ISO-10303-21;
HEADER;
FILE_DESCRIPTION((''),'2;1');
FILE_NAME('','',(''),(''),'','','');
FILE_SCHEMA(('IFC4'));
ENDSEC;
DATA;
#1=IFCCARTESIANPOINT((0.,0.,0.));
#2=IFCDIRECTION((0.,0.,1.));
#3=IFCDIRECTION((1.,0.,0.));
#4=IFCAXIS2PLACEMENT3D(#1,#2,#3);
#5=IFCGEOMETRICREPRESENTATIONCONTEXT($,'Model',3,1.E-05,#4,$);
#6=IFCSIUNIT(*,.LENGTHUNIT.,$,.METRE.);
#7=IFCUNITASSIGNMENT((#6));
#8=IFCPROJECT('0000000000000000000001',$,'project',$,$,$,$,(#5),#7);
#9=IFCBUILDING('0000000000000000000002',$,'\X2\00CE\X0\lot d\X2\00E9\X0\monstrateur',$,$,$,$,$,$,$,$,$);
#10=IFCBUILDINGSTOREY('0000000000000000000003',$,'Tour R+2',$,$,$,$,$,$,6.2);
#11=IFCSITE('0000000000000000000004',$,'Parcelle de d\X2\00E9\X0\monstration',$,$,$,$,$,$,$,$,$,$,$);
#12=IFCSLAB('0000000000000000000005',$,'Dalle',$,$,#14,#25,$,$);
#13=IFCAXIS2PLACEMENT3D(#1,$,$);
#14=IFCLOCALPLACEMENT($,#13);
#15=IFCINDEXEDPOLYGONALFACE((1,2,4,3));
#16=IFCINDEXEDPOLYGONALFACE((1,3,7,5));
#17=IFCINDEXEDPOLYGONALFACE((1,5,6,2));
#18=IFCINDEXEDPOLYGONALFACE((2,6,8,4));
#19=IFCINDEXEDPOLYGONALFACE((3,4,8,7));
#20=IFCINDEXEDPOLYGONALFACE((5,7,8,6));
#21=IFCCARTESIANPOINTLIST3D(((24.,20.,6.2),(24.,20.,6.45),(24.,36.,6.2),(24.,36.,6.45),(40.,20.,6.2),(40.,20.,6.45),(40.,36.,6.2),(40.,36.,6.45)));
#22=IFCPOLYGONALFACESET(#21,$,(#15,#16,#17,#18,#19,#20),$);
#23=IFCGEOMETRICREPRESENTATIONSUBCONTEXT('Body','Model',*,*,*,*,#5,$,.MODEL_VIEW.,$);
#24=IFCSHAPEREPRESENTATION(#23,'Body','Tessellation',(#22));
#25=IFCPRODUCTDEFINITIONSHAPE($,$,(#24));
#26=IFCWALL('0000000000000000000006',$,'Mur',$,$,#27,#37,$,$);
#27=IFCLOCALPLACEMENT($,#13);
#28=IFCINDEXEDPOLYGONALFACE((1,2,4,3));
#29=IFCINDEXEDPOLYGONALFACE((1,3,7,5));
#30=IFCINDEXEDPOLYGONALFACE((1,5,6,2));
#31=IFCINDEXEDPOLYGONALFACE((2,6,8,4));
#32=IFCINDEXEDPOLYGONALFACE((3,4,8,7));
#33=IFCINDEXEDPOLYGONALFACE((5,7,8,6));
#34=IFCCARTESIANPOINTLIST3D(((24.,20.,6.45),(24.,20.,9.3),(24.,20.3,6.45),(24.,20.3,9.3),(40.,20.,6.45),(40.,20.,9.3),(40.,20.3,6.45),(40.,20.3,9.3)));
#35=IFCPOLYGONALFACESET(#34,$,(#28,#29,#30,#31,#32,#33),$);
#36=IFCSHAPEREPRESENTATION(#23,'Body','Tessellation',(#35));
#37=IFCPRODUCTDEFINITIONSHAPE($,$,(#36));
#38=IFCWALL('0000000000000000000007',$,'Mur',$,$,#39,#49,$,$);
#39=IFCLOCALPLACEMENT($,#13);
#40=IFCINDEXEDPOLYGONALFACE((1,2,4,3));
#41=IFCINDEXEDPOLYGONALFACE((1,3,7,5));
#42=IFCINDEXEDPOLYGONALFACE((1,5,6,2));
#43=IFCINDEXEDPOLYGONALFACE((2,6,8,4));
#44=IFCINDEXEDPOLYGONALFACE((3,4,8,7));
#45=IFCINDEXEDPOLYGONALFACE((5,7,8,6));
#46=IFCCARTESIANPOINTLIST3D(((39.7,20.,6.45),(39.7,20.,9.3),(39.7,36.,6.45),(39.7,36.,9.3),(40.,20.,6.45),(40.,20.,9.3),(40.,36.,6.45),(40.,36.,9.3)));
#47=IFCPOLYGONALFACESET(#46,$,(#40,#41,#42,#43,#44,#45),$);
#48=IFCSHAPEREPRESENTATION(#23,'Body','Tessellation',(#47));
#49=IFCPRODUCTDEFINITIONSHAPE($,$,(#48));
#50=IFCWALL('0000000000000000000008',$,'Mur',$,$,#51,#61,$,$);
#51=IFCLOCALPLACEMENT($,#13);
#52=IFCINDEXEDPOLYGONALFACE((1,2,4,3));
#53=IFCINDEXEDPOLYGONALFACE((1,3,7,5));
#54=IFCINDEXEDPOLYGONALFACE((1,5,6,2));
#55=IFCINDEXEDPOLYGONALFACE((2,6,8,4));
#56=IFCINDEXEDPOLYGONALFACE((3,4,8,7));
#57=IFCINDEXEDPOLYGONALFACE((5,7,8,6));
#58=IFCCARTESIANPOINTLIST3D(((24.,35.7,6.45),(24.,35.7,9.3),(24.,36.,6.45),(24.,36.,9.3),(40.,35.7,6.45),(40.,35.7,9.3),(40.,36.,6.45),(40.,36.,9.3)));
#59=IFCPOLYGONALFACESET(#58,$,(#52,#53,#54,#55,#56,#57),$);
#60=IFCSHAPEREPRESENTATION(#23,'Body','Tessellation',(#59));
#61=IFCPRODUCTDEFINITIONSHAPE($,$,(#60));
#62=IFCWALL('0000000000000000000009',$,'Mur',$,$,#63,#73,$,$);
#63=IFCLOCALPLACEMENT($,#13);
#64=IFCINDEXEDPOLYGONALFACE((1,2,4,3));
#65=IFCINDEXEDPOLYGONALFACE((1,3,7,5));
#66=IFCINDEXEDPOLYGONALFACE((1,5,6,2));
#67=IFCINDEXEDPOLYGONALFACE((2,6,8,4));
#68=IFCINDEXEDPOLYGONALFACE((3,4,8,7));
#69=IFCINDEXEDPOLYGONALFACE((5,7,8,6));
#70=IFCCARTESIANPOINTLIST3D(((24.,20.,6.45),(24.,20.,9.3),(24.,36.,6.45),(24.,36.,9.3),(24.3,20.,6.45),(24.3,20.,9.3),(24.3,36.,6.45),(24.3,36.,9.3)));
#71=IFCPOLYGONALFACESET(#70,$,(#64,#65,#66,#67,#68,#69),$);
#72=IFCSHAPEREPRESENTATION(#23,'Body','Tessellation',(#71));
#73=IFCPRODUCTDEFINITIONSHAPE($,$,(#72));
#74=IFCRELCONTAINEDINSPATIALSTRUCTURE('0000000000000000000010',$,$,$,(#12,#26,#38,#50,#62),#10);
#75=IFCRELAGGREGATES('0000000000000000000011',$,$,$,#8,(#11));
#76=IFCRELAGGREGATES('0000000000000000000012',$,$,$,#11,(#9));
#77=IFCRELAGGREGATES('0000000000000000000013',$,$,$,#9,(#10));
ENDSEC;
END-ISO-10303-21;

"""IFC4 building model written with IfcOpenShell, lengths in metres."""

from ifc_helpers import new_model, si_unit, frame, origin_with_axes, place, context, subcontext, project, spatial, indexed_curve, outline, extrude, element, save


model = new_model("IFC4")

# Units and contexts
model_context = context("Model", 3, precision=1e-05, world=origin_with_axes())
body_context = subcontext(model_context, "Body", "Model", "MODEL_VIEW")
ifc_project = project(units=[si_unit("LENGTHUNIT", "METRE")], contexts=[model_context])

# Site, building, storey
site = spatial("IfcSite", under=ifc_project, Name="Parcelle de démonstration")
building = spatial("IfcBuilding", under=site, Name="Îlot démonstrateur")
storey = spatial("IfcBuildingStorey", under=building, Name="Tour R+2", Elevation=6.2)

# Slab
slab_placement = place(None, frame((0.0, 0.0, 6.2), z_axis=(0.0, 0.0, 1.0), x_axis=(1.0, 0.0, 0.0)))
element("IfcSlab", 1, at=slab_placement, inside=storey, Name="Dalle", context=body_context, shape_type="SweptSolid", body=[
    extrude(outline(indexed_curve([(24.0, 20.0), (40.0, 20.0), (40.0, 36.0), (24.0, 36.0)])), None, (0.0, 0.0, 1.0), 0.25),
])

# Walls
for number, where, z_axis, x_axis, name in (
    (2, (24.0, 20.0, 6.45), (0.0, 0.0, 1.0), (1.0, 0.0, 0.0), "Mur"),
    (3, (40.0, 20.0, 6.45), (0.0, 0.0, 1.0), (0.0, 1.0, 0.0), "Mur"),
    (4, (40.0, 36.0, 6.45), (0.0, 0.0, 1.0), (-1.0, 0.0, 0.0), "Mur"),
    (5, (24.0, 36.0, 6.45), (0.0, 0.0, 1.0), (0.0, -1.0, 0.0), "Mur"),
):
    element("IfcWall", number, at=place(None, frame(where, z_axis=z_axis, x_axis=x_axis)), inside=storey, Name=name, context=body_context, shape_type="SweptSolid", body=[
        extrude(outline(indexed_curve([(0.0, 0.0), (0.0, 0.3), (16.0, 0.3), (16.0, 0.0), (0.0, 0.0)], self_intersect=False)), origin_with_axes(), (0.0, 0.0, 1.0), 2.85),
    ])

save(model, "model.ifc")
